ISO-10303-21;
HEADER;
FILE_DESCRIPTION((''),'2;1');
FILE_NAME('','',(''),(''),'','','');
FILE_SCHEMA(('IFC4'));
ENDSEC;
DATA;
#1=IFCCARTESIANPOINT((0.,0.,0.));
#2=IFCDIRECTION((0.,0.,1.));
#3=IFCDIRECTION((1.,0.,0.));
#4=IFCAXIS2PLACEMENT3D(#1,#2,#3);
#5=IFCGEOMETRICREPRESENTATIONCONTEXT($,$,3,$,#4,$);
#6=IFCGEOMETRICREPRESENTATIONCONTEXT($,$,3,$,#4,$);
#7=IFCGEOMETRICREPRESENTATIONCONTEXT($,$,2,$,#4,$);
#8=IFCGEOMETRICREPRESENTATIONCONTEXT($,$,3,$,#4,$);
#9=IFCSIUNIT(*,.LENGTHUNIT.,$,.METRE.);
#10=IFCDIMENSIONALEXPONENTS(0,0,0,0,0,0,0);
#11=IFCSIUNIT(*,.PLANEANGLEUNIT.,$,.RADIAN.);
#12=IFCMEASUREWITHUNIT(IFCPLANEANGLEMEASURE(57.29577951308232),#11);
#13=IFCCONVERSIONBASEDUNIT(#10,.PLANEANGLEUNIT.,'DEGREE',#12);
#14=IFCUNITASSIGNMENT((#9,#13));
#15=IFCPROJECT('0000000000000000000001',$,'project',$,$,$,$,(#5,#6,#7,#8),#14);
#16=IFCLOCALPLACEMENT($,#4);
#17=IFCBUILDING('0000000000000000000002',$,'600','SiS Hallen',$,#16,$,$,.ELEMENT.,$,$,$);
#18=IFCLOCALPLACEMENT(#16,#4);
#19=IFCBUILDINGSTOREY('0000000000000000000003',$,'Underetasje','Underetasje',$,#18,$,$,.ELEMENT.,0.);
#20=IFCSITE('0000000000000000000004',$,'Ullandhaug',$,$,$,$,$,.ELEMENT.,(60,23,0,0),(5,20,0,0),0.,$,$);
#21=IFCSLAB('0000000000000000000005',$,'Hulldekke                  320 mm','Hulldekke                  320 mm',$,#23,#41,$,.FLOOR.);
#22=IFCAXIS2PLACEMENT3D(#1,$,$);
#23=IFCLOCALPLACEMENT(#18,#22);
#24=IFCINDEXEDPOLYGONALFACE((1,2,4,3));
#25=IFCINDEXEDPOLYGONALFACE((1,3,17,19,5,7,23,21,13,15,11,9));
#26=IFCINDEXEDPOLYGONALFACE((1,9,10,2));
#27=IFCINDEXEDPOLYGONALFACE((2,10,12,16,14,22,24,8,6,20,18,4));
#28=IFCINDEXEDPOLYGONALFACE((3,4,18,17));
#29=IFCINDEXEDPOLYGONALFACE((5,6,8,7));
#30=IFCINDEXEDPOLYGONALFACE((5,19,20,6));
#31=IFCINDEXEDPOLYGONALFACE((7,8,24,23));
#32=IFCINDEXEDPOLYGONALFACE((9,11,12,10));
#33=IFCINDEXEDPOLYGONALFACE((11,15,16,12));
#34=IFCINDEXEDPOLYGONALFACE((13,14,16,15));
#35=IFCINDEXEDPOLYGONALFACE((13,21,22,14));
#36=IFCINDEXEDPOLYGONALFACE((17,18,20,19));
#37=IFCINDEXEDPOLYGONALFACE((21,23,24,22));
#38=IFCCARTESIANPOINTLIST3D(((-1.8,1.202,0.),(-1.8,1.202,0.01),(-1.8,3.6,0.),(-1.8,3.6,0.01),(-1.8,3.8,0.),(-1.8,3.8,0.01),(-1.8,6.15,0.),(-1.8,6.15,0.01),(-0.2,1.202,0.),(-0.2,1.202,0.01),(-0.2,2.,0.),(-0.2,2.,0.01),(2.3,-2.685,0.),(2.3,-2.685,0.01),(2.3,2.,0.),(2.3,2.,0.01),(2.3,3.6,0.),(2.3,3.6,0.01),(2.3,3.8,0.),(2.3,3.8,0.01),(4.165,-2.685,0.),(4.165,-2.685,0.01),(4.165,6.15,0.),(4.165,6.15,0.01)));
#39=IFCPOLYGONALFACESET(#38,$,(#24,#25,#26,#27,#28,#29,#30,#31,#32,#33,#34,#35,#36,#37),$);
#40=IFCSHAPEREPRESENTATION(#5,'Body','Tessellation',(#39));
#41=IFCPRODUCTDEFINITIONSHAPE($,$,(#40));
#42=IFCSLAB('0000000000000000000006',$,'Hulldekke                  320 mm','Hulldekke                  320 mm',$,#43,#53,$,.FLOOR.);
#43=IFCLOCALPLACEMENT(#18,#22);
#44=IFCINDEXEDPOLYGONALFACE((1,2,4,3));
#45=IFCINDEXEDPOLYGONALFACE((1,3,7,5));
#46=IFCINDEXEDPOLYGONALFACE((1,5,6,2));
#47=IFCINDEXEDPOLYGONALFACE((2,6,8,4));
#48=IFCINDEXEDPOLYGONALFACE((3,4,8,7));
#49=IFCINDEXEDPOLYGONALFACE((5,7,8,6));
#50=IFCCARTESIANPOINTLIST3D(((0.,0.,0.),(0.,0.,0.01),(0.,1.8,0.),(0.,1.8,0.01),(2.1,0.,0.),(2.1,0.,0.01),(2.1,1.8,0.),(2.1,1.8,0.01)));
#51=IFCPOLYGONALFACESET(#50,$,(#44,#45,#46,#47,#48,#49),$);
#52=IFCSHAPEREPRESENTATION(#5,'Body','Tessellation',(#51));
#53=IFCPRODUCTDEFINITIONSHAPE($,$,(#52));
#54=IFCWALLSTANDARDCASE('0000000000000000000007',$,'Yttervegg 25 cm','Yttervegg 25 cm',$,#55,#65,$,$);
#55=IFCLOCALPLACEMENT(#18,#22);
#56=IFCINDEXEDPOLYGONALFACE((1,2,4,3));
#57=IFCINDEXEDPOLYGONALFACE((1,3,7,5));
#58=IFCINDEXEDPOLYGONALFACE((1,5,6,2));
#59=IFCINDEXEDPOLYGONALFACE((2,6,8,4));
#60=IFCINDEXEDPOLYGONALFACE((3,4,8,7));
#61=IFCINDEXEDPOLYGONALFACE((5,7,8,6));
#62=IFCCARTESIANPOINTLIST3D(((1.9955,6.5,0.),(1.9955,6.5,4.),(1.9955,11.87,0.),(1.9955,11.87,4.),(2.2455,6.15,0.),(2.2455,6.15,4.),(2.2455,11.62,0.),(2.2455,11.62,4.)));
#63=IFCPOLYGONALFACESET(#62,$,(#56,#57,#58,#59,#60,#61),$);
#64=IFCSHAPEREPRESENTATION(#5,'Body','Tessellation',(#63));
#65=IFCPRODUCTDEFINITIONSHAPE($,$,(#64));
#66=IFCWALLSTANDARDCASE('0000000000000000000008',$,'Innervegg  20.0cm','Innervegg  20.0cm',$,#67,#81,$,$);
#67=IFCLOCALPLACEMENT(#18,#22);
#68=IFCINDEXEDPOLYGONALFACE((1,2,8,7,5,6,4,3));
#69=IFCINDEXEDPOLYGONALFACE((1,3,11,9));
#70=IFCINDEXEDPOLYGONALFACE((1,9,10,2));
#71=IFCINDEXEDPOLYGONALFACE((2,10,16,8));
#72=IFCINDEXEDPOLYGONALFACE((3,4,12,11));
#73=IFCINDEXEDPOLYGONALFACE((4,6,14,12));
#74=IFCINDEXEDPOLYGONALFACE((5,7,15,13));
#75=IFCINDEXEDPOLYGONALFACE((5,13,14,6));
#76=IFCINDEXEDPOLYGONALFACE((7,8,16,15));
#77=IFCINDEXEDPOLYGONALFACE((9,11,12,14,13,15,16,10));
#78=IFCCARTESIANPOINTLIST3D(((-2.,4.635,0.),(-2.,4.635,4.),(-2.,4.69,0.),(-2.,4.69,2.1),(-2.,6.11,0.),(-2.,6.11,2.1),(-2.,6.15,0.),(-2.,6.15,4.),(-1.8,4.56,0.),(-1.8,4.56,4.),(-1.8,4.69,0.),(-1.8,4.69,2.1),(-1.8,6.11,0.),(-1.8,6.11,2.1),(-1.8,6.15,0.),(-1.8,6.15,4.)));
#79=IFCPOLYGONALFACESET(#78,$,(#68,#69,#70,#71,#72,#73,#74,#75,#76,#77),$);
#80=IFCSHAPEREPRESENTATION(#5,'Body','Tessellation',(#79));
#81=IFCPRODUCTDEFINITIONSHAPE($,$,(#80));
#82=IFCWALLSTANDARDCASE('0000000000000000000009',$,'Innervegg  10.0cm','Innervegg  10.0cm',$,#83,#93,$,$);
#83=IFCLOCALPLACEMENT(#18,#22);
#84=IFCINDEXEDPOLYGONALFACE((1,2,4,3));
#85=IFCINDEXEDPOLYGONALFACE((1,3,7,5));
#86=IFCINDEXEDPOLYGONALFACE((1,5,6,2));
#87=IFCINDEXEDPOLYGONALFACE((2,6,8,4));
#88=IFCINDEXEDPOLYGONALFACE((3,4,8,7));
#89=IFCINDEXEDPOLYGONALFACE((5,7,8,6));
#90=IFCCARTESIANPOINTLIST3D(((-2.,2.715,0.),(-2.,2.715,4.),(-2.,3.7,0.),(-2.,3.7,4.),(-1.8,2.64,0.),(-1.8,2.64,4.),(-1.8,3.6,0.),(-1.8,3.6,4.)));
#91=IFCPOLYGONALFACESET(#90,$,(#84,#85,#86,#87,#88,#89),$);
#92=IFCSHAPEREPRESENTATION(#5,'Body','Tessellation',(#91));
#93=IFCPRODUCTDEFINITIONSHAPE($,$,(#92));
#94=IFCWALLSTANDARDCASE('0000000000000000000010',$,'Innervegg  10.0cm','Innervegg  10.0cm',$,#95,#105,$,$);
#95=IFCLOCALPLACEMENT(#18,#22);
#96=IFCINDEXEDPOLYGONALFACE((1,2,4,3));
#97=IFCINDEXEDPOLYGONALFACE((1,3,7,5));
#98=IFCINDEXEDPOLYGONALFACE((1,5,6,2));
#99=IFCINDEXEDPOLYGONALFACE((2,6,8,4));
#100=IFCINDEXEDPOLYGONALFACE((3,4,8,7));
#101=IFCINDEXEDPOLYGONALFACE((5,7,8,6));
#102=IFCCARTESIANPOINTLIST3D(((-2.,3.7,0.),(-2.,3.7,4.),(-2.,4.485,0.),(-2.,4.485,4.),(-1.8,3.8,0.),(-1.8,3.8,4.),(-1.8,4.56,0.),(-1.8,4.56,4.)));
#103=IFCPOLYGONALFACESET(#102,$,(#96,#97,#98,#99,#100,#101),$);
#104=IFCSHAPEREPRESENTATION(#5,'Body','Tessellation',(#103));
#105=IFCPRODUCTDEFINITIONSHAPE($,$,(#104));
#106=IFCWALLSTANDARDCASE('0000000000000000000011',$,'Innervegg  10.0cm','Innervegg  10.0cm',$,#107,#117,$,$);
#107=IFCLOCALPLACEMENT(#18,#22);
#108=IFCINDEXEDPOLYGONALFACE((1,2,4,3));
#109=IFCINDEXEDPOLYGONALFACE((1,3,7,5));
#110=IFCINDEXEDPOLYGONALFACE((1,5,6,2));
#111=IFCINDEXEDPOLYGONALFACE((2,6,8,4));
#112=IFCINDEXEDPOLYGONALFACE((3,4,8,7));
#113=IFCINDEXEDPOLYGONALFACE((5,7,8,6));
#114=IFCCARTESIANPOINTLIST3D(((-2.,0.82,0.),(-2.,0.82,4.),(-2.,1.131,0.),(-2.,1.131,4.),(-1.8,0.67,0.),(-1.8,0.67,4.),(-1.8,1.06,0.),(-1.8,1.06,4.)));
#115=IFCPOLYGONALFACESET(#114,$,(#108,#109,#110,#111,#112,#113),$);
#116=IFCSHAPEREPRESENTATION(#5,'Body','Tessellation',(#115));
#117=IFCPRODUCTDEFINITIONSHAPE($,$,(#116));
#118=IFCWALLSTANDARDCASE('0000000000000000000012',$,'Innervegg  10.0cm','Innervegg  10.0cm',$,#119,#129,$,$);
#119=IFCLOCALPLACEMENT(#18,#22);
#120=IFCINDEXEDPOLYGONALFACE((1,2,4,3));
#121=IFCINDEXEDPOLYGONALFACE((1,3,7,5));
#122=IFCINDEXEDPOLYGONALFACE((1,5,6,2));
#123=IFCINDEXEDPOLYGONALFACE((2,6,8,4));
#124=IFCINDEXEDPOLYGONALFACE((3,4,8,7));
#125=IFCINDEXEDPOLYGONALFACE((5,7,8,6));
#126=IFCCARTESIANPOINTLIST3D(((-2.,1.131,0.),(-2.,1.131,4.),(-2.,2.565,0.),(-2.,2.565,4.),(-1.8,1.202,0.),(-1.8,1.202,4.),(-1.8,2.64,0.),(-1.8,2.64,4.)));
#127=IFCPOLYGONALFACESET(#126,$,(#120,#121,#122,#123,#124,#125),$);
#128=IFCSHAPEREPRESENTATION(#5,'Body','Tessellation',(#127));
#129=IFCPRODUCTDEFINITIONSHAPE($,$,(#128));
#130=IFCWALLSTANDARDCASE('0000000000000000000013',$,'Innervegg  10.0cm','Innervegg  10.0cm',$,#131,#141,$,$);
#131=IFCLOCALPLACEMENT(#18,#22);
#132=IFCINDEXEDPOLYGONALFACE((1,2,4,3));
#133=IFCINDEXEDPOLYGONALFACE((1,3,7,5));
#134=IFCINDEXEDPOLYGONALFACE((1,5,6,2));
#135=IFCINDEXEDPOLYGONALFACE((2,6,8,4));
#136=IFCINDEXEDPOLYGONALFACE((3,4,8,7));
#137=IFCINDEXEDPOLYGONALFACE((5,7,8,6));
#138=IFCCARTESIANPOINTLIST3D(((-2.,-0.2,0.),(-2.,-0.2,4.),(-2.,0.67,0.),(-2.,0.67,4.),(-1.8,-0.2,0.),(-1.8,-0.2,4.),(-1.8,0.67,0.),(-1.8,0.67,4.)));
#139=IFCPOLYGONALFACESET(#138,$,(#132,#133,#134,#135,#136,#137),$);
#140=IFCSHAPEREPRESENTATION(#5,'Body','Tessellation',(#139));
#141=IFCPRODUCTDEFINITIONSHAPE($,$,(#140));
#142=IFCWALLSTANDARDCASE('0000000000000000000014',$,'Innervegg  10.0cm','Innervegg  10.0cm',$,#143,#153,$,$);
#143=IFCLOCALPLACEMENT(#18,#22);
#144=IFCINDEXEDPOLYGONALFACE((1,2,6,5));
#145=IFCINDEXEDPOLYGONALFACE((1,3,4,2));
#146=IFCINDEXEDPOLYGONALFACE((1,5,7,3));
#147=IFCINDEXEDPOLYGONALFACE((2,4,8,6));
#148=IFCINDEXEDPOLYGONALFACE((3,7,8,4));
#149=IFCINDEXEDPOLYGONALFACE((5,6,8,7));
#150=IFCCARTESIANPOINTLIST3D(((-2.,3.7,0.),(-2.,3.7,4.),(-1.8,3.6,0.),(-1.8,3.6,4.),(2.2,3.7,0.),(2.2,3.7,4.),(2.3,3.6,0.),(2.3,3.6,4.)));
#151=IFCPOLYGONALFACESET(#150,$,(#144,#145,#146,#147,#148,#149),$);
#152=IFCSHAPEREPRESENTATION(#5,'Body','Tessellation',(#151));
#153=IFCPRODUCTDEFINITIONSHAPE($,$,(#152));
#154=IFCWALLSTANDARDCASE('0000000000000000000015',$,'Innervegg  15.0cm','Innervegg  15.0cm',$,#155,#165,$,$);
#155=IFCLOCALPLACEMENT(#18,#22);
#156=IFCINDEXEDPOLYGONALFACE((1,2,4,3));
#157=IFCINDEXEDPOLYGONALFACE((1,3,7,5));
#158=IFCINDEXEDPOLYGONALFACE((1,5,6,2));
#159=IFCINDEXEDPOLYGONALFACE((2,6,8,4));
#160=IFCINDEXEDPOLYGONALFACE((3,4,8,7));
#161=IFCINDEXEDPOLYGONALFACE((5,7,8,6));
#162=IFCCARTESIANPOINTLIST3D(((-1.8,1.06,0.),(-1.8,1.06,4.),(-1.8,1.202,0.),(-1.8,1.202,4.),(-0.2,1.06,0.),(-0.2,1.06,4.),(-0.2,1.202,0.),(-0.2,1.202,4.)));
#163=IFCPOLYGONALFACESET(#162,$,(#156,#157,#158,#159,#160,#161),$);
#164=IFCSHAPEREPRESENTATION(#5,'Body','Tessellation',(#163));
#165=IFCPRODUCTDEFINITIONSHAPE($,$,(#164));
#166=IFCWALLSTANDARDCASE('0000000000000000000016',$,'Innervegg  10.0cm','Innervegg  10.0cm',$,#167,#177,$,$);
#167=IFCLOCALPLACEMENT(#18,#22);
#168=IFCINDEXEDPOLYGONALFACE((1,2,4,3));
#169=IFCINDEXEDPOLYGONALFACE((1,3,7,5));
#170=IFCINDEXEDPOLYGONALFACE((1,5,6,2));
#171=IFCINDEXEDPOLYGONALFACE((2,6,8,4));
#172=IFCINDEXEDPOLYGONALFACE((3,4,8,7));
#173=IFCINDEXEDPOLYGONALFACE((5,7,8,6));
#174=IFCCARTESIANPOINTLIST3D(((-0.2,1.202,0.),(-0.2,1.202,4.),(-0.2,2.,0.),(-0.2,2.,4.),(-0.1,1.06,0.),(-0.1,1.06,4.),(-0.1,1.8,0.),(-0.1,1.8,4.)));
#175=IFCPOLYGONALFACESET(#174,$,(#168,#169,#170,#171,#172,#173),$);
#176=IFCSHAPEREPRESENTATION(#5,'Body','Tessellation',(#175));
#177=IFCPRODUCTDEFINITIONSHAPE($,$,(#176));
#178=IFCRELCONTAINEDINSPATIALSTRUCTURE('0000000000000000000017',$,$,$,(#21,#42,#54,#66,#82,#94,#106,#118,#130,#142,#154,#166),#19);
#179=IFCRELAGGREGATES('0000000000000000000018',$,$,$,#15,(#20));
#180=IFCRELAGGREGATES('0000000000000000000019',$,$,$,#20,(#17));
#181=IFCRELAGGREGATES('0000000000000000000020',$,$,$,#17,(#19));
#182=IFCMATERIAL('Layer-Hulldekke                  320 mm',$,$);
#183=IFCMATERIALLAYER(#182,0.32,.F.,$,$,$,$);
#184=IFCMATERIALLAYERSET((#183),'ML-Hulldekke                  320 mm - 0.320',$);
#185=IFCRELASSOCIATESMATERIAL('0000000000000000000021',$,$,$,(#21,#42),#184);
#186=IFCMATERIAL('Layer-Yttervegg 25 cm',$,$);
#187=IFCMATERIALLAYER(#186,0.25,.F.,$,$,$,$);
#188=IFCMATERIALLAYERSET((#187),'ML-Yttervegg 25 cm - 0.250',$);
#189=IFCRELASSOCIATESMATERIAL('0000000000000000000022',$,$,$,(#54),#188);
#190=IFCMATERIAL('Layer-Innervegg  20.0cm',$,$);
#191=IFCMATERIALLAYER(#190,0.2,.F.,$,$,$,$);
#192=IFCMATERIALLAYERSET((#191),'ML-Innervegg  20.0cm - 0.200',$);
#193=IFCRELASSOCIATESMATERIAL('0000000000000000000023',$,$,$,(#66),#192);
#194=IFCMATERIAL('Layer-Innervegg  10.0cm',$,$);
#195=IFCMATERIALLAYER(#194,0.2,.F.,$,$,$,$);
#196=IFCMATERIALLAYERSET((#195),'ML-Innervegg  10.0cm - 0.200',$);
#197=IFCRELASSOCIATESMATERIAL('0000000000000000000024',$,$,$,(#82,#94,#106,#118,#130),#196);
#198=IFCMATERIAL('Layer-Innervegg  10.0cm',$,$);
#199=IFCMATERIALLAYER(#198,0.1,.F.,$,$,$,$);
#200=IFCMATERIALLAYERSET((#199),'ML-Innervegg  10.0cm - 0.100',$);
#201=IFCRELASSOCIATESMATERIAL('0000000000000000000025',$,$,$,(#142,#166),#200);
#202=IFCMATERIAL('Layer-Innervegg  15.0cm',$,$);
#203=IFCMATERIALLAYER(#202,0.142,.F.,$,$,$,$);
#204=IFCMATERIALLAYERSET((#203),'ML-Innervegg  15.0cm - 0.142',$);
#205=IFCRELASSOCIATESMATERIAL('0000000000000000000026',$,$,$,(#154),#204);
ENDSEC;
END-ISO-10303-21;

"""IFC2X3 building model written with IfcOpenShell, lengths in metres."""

from ifc_helpers import new_model, entity, si_unit, converted_unit, frame, origin_with_axes, place, context, project, spatial, polyline, outline, extrude, material, layer, layer_set, layer_usage, element, save


model = new_model("IFC2X3")

# Units and contexts
context_of_model_1 = context(None, 3, world=origin_with_axes())
context_of_model_2 = context(None, 3, world=origin_with_axes())
context_of_model_3 = context(None, 2, world=origin_with_axes())
context_of_model_4 = context(None, 3, world=origin_with_axes())
ifc_project = project(units=[si_unit("LENGTHUNIT", "METRE"), converted_unit("PLANEANGLEUNIT", "DEGREE", entity("IfcPlaneAngleMeasure", 57.29577951308232), si_unit("PLANEANGLEUNIT", "RADIAN"), dimensions=[0, 0, 0, 0, 0, 0, 0])], contexts=[context_of_model_1, context_of_model_2, context_of_model_3, context_of_model_4])

# Site, building, storey
site = spatial("IfcSite", under=ifc_project, Name="Ullandhaug", CompositionType="ELEMENT", RefLatitude=(60, 23, 0, 0), RefLongitude=(5, 20, 0, 0), RefElevation=0.0)
building_placement = place(None, origin_with_axes())
building = spatial("IfcBuilding", under=site, at=building_placement, Name="600", Description="SiS Hallen", CompositionType="ELEMENT")
storey_placement = place(building_placement, origin_with_axes())
storey = spatial("IfcBuildingStorey", under=building, at=storey_placement, Name="Underetasje", Description="Underetasje", CompositionType="ELEMENT", Elevation=0.0)

# Slabs
ifc_material_1 = material(Name="Layer-Hulldekke                  320 mm")
ifc_layer_1 = layer(ifc_material_1, 0.32, ventilated=False)
ifc_layer_set_1 = layer_set([ifc_layer_1], Name="ML-Hulldekke                  320 mm - 0.320")
ifc_layer_usage_1 = layer_usage(ifc_layer_set_1, "AXIS2", "POSITIVE", 0.0)
slab_1_placement = place(storey_placement, frame((-1.8, 3.8, 0.0), z_axis=(0.0, 0.0, 1.0), x_axis=(1.0, 0.0, 0.0)))
element("IfcSlab", 1, at=slab_1_placement, inside=storey, material=ifc_layer_usage_1, Name="Hulldekke                  320 mm", Description="Hulldekke                  320 mm", PredefinedType="FLOOR", context=context_of_model_1, shape_type="SweptSolid", body=[
    extrude(outline(polyline([(0.0, 0.0), (4.1, 0.0), (4.1, 0.2), (0.0, 0.2), (0.0, 2.598), (1.6, 2.598), (1.6, 1.8), (4.1, 1.8), (4.1, 6.485), (5.965, 6.485), (5.965, -2.35), (0.0, -2.35), (0.0, 0.0)])), frame((0.0, 0.0, 0.0), z_axis=(0.0, 0.0, -1.0), x_axis=(1.0, 0.0, 0.0)), (0.0, 0.0, -1.0), 0.01),
])
slab_2_placement = place(storey_placement, origin_with_axes())
element("IfcSlab", 2, at=slab_2_placement, inside=storey, material=ifc_layer_usage_1, Name="Hulldekke                  320 mm", Description="Hulldekke                  320 mm", PredefinedType="FLOOR", context=context_of_model_1, shape_type="SweptSolid", body=[
    extrude(outline(polyline([(0.0, 0.0), (2.1, 0.0), (2.1, 1.8), (0.0, 1.8), (0.0, 0.0)])), origin_with_axes(), (0.0, 0.0, 1.0), 0.01),
])

# Wall
ifc_material_2 = material(Name="Layer-Yttervegg 25 cm")
ifc_layer_2 = layer(ifc_material_2, 0.25, ventilated=False)
ifc_layer_set_2 = layer_set([ifc_layer_2], Name="ML-Yttervegg 25 cm - 0.250")
ifc_layer_usage_2 = layer_usage(ifc_layer_set_2, "AXIS2", "POSITIVE", 0.0)
wall_1_placement = place(storey_placement, frame((1.9955, 11.87, 0.0), z_axis=(0.0, 0.0, 1.0), x_axis=(0.0, -1.0, 0.0)))
element("IfcWallStandardCase", 3, at=wall_1_placement, inside=storey, material=ifc_layer_usage_2, Name="Yttervegg 25 cm", Description="Yttervegg 25 cm", context=context_of_model_1, shape_type="SweptSolid", body=[
    extrude(outline(polyline([(0.0, 0.0), (5.37, 0.0), (5.72, 0.25), (0.25, 0.25), (0.0, 0.0)])), frame((0.0, 0.0, 0.0), z_axis=(0.0, 0.0, 1.0), x_axis=(1.0, 0.0, 0.0)), (0.0, 0.0, 1.0), 4.0),
])

# Wall, opening
ifc_material_3 = material(Name="Layer-Innervegg  20.0cm")
ifc_layer_3 = layer(ifc_material_3, 0.2, ventilated=False)
ifc_layer_set_3 = layer_set([ifc_layer_3], Name="ML-Innervegg  20.0cm - 0.200")
ifc_layer_usage_3 = layer_usage(ifc_layer_set_3, "AXIS2", "POSITIVE", 0.0)
wall_2_placement = place(storey_placement, frame((-1.8, 4.56, 0.0), z_axis=(0.0, 0.0, 1.0), x_axis=(0.0, 1.0, 0.0)))
wall_2 = element("IfcWallStandardCase", 4, at=wall_2_placement, inside=storey, material=ifc_layer_usage_3, Name="Innervegg  20.0cm", Description="Innervegg  20.0cm", context=context_of_model_1, shape_type="SweptSolid", body=[
    extrude(outline(polyline([(0.0, 0.0), (1.59, 0.0), (1.59, 0.2), (0.075, 0.2), (0.0, 0.0)])), frame((0.0, 0.0, 0.0), z_axis=(0.0, 0.0, 1.0), x_axis=(1.0, 0.0, 0.0)), (0.0, 0.0, 1.0), 4.0),
])
opening_1_placement = place(wall_2_placement, frame((0.13, 0.2, 0.0), z_axis=(0.0, 0.0, 1.0), x_axis=(1.0, 0.0, 0.0)))
element("IfcOpeningElement", 5, at=opening_1_placement, cuts=wall_2, context=context_of_model_1, shape_type="SweptSolid", body=[
    extrude(outline(polyline([(0.0, 0.0), (2.1, 0.0), (2.1, 1.42), (0.0, 1.42), (0.0, 0.0)])), frame((0.0, 0.0, 0.0), z_axis=(0.0, 1.0, 0.0), x_axis=(0.0, 0.0, 1.0)), (0.0, 0.0, -1.0), 0.2),
])

# Walls
ifc_material_4 = material(Name="Layer-Innervegg  10.0cm")
ifc_layer_4 = layer(ifc_material_4, 0.2, ventilated=False)
ifc_layer_set_4 = layer_set([ifc_layer_4], Name="ML-Innervegg  10.0cm - 0.200")
ifc_layer_usage_4 = layer_usage(ifc_layer_set_4, "AXIS2", "POSITIVE", 0.0)
wall_3_placement = place(storey_placement, frame((-1.8, 2.64, 0.0), z_axis=(0.0, 0.0, 1.0), x_axis=(0.0, 1.0, 0.0)))
element("IfcWallStandardCase", 6, at=wall_3_placement, inside=storey, material=ifc_layer_usage_4, Name="Innervegg  10.0cm", Description="Innervegg  10.0cm", context=context_of_model_1, shape_type="SweptSolid", body=[
    extrude(outline(polyline([(0.0, 0.0), (0.96, 0.0), (1.06, 0.2), (0.075, 0.2), (0.0, 0.0)])), frame((0.0, 0.0, 0.0), z_axis=(0.0, 0.0, 1.0), x_axis=(1.0, 0.0, 0.0)), (0.0, 0.0, 1.0), 4.0),
])
wall_4_placement = place(storey_placement, frame((-1.8, 3.8, 0.0), z_axis=(0.0, 0.0, 1.0), x_axis=(0.0, 1.0, 0.0)))
element("IfcWallStandardCase", 7, at=wall_4_placement, inside=storey, material=ifc_layer_usage_4, Name="Innervegg  10.0cm", Description="Innervegg  10.0cm", context=context_of_model_1, shape_type="SweptSolid", body=[
    extrude(outline(polyline([(0.0, 0.0), (0.76, 0.0), (0.685, 0.2), (-0.1, 0.2), (0.0, 0.0)])), frame((0.0, 0.0, 0.0), z_axis=(0.0, 0.0, 1.0), x_axis=(1.0, 0.0, 0.0)), (0.0, 0.0, 1.0), 4.0),
])
wall_5_placement = place(storey_placement, frame((-1.8, 0.67, 0.0), z_axis=(0.0, 0.0, 1.0), x_axis=(0.0, 1.0, 0.0)))
element("IfcWallStandardCase", 8, at=wall_5_placement, inside=storey, material=ifc_layer_usage_4, Name="Innervegg  10.0cm", Description="Innervegg  10.0cm", context=context_of_model_1, shape_type="SweptSolid", body=[
    extrude(outline(polyline([(0.0, 0.0), (0.39, 0.0), (0.461, 0.2), (0.15, 0.2), (0.0, 0.0)])), frame((0.0, 0.0, 0.0), z_axis=(0.0, 0.0, 1.0), x_axis=(1.0, 0.0, 0.0)), (0.0, 0.0, 1.0), 4.0),
])
wall_6_placement = place(storey_placement, frame((-1.8, 1.202, 0.0), z_axis=(0.0, 0.0, 1.0), x_axis=(0.0, 1.0, 0.0)))
element("IfcWallStandardCase", 9, at=wall_6_placement, inside=storey, material=ifc_layer_usage_4, Name="Innervegg  10.0cm", Description="Innervegg  10.0cm", context=context_of_model_1, shape_type="SweptSolid", body=[
    extrude(outline(polyline([(0.0, 0.0), (1.438, 0.0), (1.363, 0.2), (-0.071, 0.2), (0.0, 0.0)])), frame((0.0, 0.0, 0.0), z_axis=(0.0, 0.0, 1.0), x_axis=(1.0, 0.0, 0.0)), (0.0, 0.0, 1.0), 4.0),
])
wall_7_placement = place(storey_placement, frame((-1.8, -0.2, 0.0), z_axis=(0.0, 0.0, 1.0), x_axis=(0.0, 1.0, 0.0)))
element("IfcWallStandardCase", 10, at=wall_7_placement, inside=storey, material=ifc_layer_usage_4, Name="Innervegg  10.0cm", Description="Innervegg  10.0cm", context=context_of_model_1, shape_type="SweptSolid", body=[
    extrude(outline(polyline([(0.0, 0.0), (0.87, 0.0), (0.87, 0.2), (0.0, 0.2), (0.0, 0.0)])), frame((0.0, 0.0, 0.0), z_axis=(0.0, 0.0, 1.0), x_axis=(1.0, 0.0, 0.0)), (0.0, 0.0, 1.0), 4.0),
])
ifc_material_5 = material(Name="Layer-Innervegg  10.0cm")
ifc_layer_5 = layer(ifc_material_5, 0.1, ventilated=False)
ifc_layer_set_5 = layer_set([ifc_layer_5], Name="ML-Innervegg  10.0cm - 0.100")
ifc_layer_usage_5 = layer_usage(ifc_layer_set_5, "AXIS2", "POSITIVE", 0.0)
wall_8_placement = place(storey_placement, frame((2.2, 3.7, 0.0), z_axis=(0.0, 0.0, 1.0), x_axis=(-1.0, 0.0, 0.0)))
element("IfcWallStandardCase", 11, at=wall_8_placement, inside=storey, material=ifc_layer_usage_5, Name="Innervegg  10.0cm", Description="Innervegg  10.0cm", context=context_of_model_1, shape_type="SweptSolid", body=[
    extrude(outline(polyline([(0.0, 0.0), (4.2, 0.0), (4.0, 0.1), (-0.1, 0.1), (0.0, 0.0)])), frame((0.0, 0.0, 0.0), z_axis=(0.0, 0.0, 1.0), x_axis=(1.0, 0.0, 0.0)), (0.0, 0.0, 1.0), 4.0),
])
ifc_material_6 = material(Name="Layer-Innervegg  15.0cm")
ifc_layer_6 = layer(ifc_material_6, 0.142, ventilated=False)
ifc_layer_set_6 = layer_set([ifc_layer_6], Name="ML-Innervegg  15.0cm - 0.142")
ifc_layer_usage_6 = layer_usage(ifc_layer_set_6, "AXIS2", "POSITIVE", 0.0)
wall_9_placement = place(storey_placement, frame((-1.8, 1.06, 0.0), z_axis=(0.0, 0.0, 1.0), x_axis=(1.0, 0.0, 0.0)))
element("IfcWallStandardCase", 12, at=wall_9_placement, inside=storey, material=ifc_layer_usage_6, Name="Innervegg  15.0cm", Description="Innervegg  15.0cm", context=context_of_model_1, shape_type="SweptSolid", body=[
    extrude(outline(polyline([(0.0, 0.0), (1.6, 0.0), (1.6, 0.142), (0.0, 0.142), (0.0, 0.0)])), origin_with_axes(), (0.0, 0.0, 1.0), 4.0),
])
wall_10_placement = place(storey_placement, frame((-0.1, 1.06, 0.0), z_axis=(0.0, 0.0, 1.0), x_axis=(0.0, 1.0, 0.0)))
element("IfcWallStandardCase", 13, at=wall_10_placement, inside=storey, material=ifc_layer_usage_5, Name="Innervegg  10.0cm", Description="Innervegg  10.0cm", context=context_of_model_1, shape_type="SweptSolid", body=[
    extrude(outline(polyline([(0.0, 0.0), (0.74, 0.0), (0.94, 0.1), (0.142, 0.1), (0.0, 0.0)])), frame((0.0, 0.0, 0.0), z_axis=(0.0, 0.0, 1.0), x_axis=(1.0, 0.0, 0.0)), (0.0, 0.0, 1.0), 4.0),
])

save(model, "model.ifc")
